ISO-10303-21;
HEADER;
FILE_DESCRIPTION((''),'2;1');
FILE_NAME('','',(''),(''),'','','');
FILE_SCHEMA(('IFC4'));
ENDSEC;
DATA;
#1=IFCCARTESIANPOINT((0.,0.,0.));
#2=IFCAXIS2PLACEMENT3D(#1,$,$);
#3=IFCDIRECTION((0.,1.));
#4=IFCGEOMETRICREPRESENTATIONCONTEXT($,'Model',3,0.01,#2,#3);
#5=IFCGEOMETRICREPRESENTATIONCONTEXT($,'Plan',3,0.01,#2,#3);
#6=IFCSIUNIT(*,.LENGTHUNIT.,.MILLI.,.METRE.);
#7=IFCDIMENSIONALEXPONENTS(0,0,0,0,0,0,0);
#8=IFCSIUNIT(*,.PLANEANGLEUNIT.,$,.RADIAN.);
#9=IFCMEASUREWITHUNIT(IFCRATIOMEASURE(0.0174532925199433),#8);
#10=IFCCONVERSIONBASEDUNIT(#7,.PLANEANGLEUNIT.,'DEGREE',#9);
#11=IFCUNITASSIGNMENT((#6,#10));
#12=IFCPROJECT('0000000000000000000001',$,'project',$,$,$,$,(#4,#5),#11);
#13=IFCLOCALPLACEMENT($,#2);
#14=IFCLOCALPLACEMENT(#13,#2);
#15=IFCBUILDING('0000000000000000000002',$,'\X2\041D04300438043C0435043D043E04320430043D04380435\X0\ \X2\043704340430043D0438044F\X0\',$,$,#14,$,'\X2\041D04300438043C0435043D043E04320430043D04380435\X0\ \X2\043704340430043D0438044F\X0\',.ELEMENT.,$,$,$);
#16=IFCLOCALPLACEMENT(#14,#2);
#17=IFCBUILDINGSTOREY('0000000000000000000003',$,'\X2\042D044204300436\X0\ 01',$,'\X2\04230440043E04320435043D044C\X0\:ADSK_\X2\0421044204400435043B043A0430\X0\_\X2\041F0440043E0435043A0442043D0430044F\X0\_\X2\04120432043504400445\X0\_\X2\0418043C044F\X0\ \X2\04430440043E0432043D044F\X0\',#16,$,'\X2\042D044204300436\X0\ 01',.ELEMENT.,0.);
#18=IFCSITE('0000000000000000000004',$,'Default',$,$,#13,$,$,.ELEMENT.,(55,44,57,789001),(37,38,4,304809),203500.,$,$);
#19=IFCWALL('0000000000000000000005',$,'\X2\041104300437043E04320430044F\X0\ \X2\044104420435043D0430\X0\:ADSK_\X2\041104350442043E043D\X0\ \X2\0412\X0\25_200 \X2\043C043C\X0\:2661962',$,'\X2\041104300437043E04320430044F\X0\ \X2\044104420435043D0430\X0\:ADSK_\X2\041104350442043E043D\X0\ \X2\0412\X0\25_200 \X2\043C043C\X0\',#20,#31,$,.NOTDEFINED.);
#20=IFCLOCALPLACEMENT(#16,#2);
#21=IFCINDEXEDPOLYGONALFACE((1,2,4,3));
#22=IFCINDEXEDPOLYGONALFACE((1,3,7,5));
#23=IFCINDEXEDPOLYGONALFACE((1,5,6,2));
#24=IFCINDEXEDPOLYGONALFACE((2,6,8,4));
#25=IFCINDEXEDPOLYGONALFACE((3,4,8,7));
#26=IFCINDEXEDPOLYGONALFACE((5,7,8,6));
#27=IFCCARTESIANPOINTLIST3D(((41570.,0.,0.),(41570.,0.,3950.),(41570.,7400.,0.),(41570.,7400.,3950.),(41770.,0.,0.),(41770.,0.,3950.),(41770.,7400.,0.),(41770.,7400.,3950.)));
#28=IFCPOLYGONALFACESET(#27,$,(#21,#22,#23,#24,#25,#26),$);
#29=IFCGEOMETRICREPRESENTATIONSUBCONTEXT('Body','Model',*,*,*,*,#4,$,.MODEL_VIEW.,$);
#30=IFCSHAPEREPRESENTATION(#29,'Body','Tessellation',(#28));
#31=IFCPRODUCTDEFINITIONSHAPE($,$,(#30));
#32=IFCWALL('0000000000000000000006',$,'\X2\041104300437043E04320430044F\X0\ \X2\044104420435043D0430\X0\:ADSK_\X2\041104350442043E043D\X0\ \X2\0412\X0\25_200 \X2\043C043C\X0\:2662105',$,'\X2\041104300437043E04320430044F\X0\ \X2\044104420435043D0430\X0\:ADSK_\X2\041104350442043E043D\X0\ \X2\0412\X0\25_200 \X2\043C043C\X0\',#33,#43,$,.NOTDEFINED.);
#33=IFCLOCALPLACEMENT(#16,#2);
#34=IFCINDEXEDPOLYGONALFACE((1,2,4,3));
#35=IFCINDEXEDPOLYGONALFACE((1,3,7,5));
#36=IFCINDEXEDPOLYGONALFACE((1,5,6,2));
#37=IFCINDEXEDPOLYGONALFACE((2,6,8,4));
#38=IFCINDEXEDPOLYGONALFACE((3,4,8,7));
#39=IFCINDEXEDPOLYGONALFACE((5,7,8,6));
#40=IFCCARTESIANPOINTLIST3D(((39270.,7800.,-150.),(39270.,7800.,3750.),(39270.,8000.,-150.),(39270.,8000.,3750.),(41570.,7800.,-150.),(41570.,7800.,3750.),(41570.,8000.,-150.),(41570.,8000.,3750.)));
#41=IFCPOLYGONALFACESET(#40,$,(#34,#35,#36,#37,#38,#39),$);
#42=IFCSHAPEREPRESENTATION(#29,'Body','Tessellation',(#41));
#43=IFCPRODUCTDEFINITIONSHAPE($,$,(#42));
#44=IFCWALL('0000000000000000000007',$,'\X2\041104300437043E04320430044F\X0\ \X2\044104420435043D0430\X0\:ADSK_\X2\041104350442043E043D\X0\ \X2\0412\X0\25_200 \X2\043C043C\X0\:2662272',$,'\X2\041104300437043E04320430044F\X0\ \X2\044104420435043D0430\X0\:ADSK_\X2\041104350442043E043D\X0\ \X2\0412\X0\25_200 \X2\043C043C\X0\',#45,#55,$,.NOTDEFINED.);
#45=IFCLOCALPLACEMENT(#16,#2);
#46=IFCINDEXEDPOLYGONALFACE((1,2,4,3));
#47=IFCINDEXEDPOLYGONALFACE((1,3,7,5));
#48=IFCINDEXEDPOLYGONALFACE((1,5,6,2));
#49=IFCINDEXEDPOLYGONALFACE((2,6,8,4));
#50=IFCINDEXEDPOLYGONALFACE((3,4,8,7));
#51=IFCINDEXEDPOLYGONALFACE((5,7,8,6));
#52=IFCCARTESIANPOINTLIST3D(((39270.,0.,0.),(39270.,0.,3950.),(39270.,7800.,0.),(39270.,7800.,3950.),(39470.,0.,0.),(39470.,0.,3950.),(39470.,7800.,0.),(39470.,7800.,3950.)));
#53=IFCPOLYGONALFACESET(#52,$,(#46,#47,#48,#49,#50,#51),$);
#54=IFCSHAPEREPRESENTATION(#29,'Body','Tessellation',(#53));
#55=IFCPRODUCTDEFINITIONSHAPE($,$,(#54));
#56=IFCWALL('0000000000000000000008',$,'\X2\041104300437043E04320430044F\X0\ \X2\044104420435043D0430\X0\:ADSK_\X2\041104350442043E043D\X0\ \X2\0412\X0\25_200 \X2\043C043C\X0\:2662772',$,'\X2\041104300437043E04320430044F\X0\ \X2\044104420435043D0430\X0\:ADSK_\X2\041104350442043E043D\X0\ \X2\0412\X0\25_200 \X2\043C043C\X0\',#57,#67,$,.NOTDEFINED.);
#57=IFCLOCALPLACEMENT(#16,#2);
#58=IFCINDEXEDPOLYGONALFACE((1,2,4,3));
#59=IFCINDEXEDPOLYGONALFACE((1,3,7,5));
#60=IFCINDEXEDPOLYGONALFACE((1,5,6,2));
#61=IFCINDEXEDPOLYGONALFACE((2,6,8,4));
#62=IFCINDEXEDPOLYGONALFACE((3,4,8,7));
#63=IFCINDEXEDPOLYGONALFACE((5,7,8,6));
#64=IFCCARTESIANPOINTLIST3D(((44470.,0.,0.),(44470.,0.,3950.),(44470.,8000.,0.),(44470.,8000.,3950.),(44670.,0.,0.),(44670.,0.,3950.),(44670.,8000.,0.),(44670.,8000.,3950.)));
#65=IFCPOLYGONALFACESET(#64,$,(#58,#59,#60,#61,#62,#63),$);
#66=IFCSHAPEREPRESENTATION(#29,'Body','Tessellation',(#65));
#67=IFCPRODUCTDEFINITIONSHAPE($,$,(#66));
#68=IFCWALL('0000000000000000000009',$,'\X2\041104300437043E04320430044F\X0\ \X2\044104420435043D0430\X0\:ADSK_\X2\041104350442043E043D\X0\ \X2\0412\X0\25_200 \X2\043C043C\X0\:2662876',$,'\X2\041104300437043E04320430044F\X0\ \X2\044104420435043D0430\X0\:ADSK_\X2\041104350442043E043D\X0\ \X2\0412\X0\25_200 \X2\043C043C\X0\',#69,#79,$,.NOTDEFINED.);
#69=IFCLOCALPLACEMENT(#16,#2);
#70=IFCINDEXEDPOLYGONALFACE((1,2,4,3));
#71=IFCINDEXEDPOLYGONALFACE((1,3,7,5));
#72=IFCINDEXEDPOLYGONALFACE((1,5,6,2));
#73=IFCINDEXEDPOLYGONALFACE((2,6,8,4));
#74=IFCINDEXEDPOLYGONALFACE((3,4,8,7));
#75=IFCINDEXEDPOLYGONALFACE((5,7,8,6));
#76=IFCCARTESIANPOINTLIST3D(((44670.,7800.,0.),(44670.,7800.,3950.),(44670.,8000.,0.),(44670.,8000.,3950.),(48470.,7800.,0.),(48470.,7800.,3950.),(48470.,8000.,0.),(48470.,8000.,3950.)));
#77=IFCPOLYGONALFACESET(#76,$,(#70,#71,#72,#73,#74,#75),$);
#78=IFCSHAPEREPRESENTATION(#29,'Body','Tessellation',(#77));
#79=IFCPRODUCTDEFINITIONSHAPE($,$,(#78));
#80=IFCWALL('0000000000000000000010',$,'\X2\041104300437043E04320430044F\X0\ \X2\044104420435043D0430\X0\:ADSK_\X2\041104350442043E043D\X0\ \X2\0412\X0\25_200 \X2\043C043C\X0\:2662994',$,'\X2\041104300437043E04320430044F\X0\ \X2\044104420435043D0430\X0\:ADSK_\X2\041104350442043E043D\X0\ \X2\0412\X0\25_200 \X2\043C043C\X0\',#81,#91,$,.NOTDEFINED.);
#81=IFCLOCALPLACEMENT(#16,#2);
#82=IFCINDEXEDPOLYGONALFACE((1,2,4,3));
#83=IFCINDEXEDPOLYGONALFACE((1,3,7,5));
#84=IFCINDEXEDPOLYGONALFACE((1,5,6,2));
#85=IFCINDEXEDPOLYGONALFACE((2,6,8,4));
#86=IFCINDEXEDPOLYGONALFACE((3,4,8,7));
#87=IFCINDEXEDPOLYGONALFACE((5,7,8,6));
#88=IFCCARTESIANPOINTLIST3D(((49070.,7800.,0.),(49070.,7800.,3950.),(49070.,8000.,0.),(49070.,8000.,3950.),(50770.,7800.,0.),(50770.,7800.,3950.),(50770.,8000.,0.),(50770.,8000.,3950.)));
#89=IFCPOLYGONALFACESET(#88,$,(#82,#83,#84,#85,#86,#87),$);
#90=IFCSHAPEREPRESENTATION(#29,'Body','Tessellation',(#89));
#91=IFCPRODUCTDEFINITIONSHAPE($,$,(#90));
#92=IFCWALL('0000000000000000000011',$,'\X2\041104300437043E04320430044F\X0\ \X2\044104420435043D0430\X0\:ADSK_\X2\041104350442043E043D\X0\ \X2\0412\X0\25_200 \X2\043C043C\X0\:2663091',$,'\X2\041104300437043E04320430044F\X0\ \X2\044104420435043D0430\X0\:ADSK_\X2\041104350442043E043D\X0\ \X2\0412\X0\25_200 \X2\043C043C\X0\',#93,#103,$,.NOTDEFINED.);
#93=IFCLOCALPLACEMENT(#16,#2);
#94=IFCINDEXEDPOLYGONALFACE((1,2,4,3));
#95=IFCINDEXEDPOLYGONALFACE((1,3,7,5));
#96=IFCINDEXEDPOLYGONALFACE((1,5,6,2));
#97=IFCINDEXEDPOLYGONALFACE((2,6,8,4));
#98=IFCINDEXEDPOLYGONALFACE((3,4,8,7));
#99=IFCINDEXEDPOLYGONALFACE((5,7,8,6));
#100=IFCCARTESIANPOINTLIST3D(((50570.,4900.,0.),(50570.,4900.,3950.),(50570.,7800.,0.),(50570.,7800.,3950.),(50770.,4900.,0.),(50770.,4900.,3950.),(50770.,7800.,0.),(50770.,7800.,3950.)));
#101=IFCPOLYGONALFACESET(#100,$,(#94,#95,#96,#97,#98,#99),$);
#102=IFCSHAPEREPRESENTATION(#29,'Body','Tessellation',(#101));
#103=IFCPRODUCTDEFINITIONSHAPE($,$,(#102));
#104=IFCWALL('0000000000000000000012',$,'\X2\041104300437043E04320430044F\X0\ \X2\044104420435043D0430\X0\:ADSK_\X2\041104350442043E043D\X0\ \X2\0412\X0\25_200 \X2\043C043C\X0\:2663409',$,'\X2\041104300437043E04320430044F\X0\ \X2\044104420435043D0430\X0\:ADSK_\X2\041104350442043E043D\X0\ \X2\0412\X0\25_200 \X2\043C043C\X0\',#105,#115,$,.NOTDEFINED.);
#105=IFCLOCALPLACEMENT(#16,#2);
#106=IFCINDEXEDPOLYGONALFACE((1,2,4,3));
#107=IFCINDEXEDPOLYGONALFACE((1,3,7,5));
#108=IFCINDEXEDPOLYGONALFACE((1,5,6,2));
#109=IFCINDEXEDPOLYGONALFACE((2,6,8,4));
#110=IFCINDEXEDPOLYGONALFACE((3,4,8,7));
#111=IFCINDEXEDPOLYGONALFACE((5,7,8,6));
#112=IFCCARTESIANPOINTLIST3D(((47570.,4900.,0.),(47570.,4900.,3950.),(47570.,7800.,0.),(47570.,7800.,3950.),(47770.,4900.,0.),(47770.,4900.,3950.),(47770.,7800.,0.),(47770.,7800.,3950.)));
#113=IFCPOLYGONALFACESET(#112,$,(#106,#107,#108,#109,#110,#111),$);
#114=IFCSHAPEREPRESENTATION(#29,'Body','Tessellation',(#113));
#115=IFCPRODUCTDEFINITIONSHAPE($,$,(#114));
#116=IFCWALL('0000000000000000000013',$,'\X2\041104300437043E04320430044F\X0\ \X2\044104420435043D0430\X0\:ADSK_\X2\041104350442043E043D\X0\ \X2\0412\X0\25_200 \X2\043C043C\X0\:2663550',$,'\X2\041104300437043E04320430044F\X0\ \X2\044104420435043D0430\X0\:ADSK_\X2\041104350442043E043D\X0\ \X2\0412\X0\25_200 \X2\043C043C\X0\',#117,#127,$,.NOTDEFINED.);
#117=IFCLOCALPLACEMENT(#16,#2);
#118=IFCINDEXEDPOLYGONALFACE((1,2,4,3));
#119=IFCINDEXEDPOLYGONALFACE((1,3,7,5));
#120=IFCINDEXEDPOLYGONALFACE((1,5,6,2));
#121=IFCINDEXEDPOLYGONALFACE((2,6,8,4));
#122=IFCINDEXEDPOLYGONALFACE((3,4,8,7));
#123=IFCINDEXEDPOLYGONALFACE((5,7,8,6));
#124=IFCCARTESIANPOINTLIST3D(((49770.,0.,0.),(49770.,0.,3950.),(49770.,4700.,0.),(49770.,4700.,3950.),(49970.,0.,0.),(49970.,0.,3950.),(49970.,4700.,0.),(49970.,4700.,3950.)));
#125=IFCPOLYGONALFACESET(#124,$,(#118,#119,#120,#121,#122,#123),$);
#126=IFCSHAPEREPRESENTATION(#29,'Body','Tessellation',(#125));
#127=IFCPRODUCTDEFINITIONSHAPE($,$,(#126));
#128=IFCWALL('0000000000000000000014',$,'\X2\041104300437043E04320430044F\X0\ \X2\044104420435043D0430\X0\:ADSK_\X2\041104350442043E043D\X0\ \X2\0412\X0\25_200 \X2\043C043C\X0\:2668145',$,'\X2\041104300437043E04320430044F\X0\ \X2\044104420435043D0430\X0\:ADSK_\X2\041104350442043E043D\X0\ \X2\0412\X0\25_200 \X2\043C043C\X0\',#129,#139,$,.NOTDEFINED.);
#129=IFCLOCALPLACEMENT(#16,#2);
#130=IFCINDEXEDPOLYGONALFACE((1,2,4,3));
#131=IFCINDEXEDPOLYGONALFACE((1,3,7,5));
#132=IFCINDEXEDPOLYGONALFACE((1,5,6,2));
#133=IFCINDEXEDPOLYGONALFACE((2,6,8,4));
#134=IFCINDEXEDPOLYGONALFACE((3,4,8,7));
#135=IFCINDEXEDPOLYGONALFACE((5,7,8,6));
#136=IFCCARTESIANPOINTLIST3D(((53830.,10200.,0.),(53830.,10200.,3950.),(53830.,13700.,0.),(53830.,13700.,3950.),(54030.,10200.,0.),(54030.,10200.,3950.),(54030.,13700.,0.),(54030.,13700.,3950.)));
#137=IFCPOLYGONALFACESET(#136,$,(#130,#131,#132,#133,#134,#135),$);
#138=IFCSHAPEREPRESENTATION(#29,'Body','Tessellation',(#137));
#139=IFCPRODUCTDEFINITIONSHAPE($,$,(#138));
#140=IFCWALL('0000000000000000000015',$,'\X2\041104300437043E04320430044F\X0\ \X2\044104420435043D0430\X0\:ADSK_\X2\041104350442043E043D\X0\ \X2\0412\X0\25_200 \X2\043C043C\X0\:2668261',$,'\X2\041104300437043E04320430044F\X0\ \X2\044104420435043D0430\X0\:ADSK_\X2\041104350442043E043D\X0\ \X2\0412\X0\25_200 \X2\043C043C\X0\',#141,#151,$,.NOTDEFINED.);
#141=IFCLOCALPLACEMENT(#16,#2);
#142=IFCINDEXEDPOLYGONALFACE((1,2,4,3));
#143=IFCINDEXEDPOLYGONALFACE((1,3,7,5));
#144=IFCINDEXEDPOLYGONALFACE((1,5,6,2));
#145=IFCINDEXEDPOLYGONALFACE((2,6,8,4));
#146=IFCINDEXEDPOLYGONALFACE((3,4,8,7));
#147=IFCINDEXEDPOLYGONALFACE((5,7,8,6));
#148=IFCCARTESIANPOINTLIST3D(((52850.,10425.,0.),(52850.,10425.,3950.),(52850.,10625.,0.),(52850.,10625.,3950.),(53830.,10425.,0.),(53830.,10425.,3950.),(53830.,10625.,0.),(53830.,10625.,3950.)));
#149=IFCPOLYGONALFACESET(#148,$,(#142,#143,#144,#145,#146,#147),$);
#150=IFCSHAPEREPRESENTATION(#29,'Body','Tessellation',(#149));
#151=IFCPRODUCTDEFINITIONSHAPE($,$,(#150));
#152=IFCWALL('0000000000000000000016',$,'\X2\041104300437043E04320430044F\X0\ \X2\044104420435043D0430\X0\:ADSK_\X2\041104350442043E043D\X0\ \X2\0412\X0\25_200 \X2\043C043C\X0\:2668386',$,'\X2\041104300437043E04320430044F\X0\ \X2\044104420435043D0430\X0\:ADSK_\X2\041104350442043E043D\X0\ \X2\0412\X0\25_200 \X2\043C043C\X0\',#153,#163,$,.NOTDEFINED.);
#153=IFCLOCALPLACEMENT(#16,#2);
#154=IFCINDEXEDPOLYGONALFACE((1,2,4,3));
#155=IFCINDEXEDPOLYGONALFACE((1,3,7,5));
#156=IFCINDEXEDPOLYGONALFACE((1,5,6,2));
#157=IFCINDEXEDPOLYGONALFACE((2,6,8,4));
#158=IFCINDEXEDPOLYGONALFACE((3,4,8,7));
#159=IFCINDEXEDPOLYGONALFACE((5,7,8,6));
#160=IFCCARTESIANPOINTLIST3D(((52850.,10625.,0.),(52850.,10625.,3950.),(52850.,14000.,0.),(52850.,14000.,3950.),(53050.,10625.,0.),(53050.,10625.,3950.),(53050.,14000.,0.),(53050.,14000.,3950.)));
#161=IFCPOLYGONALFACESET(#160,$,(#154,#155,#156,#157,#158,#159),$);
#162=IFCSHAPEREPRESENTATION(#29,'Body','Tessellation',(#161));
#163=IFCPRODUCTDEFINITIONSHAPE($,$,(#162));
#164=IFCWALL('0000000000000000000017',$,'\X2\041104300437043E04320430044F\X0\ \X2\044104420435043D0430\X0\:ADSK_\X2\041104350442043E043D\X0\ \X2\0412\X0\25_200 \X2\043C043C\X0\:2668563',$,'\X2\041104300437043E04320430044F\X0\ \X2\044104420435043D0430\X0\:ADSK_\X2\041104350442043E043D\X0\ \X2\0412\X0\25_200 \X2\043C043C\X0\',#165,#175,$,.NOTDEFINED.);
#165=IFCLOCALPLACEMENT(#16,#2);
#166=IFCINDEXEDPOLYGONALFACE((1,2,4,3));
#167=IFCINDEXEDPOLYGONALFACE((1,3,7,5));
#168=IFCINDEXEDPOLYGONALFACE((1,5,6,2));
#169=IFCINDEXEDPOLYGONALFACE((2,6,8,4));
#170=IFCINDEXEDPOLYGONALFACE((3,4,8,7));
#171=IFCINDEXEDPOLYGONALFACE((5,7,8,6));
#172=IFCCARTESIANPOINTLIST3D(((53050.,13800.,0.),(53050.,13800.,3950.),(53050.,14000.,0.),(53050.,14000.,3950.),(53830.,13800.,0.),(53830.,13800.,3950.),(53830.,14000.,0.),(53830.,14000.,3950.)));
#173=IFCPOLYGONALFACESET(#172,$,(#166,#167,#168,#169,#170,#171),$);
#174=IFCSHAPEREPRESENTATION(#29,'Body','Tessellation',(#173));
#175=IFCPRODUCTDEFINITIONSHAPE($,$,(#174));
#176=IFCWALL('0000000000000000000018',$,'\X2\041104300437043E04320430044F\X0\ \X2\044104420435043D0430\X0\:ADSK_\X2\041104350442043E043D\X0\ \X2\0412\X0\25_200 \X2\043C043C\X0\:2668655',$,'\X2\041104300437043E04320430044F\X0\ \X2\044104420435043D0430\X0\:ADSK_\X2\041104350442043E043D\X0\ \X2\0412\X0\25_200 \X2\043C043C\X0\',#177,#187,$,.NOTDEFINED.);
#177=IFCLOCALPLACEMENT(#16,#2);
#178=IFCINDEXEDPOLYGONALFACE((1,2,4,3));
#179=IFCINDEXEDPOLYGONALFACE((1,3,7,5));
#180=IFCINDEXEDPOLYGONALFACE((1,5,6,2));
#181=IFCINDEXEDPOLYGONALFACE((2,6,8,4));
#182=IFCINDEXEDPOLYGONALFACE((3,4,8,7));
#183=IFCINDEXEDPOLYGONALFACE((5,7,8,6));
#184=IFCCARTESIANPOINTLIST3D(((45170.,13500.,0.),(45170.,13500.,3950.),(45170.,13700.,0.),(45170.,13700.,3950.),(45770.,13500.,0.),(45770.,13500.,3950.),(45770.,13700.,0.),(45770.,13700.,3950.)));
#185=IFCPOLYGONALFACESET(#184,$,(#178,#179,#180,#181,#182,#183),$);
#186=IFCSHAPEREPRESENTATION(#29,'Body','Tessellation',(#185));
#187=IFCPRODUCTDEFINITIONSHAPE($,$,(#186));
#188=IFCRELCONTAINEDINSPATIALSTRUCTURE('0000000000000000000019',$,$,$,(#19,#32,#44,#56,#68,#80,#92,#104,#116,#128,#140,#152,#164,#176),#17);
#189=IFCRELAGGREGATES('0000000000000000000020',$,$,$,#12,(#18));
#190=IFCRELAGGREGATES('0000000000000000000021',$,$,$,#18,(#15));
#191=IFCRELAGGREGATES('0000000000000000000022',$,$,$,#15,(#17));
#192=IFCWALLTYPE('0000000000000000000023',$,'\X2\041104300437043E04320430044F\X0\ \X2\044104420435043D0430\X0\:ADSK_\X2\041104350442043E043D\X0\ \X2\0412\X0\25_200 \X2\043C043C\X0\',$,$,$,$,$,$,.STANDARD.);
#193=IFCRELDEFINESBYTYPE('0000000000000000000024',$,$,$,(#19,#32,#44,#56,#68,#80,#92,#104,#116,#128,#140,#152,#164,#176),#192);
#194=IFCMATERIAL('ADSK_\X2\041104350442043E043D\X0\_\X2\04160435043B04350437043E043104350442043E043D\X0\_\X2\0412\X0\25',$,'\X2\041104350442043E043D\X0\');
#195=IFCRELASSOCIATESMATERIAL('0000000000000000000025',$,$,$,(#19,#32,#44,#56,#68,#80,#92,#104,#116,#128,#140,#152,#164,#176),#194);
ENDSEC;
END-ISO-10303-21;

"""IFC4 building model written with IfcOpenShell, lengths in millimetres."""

from ifc_helpers import new_model, entity, si_unit, converted_unit, direction, frame, origin, place, context, subcontext, project, spatial, indexed_curve, outline, extrude, material, type_object, element, save


model = new_model("IFC4")

# Units and contexts
model_context = context("Model", 3, precision=0.01, world=origin(), true_north=direction((0.0, 1.0)))
plan_context = context("Plan", 3, precision=0.01, world=origin(), true_north=direction((0.0, 1.0)))
body_context = subcontext(model_context, "Body", "Model", "MODEL_VIEW")
ifc_project = project(units=[si_unit("LENGTHUNIT", "METRE", prefix="MILLI"), converted_unit("PLANEANGLEUNIT", "DEGREE", entity("IfcRatioMeasure", 0.0174532925199433), si_unit("PLANEANGLEUNIT", "RADIAN"), dimensions=[0, 0, 0, 0, 0, 0, 0])], contexts=[model_context, plan_context])

# Site, building, storey
site_placement = place(None, origin())
site = spatial("IfcSite", under=ifc_project, at=site_placement, Name="Default", CompositionType="ELEMENT", RefLatitude=(55, 44, 57, 789001), RefLongitude=(37, 38, 4, 304809), RefElevation=203500.0)
building_placement = place(site_placement, origin())
building = spatial("IfcBuilding", under=site, at=building_placement, Name="Наименование здания", LongName="Наименование здания", CompositionType="ELEMENT")
storey_placement = place(building_placement, origin())
storey = spatial("IfcBuildingStorey", under=building, at=storey_placement, Name="Этаж 01", ObjectType="Уровень:ADSK_Стрелка_Проектная_Вверх_Имя уровня", LongName="Этаж 01", CompositionType="ELEMENT", Elevation=0.0)

# Walls
ifc_material = material(Name="ADSK_Бетон_Железобетон_В25", Category="Бетон")
wall_type_1 = type_object("IfcWallType", Name="Базовая стена:ADSK_Бетон В25_200 мм", PredefinedType="STANDARD")
wall_1_placement = place(storey_placement, frame((41670.0, 7400.0, 0.0), z_axis=(0.0, 0.0, 1.0), x_axis=(0.0, -1.0, 0.0)))
element("IfcWall", 1, at=wall_1_placement, inside=storey, type_object=wall_type_1, material=ifc_material, Name="Базовая стена:ADSK_Бетон В25_200 мм:2661962", ObjectType="Базовая стена:ADSK_Бетон В25_200 мм", PredefinedType="NOTDEFINED", context=body_context, shape_type="SweptSolid", body=[
    extrude(outline(indexed_curve([(7400.0, 100.0), (0.0, 100.0), (0.0, -100.0), (7400.0, -100.0), (7400.0, 100.0)], self_intersect=False)), origin(), (0.0, 0.0, 1.0), 3950.0),
])
wall_2_placement = place(storey_placement, frame((41570.0, 7900.0, -150.0), z_axis=(0.0, 0.0, 1.0), x_axis=(-1.0, 0.0, 0.0)))
element("IfcWall", 2, at=wall_2_placement, inside=storey, type_object=wall_type_1, material=ifc_material, Name="Базовая стена:ADSK_Бетон В25_200 мм:2662105", ObjectType="Базовая стена:ADSK_Бетон В25_200 мм", PredefinedType="NOTDEFINED", context=body_context, shape_type="SweptSolid", body=[
    extrude(outline(indexed_curve([(2300.0, 100.0), (0.0, 100.0), (0.0, -100.0), (2300.0, -100.0), (2300.0, 100.0)], self_intersect=False)), origin(), (0.0, 0.0, 1.0), 3900.0),
])
wall_3_placement = place(storey_placement, frame((39370.0, 7800.0, 0.0), z_axis=(0.0, 0.0, 1.0), x_axis=(0.0, -1.0, 0.0)))
element("IfcWall", 3, at=wall_3_placement, inside=storey, type_object=wall_type_1, material=ifc_material, Name="Базовая стена:ADSK_Бетон В25_200 мм:2662272", ObjectType="Базовая стена:ADSK_Бетон В25_200 мм", PredefinedType="NOTDEFINED", context=body_context, shape_type="SweptSolid", body=[
    extrude(outline(indexed_curve([(7800.0, 100.0), (0.0, 100.0), (0.0, -100.0), (7800.0, -100.0), (7800.0, 100.0)], self_intersect=False)), origin(), (0.0, 0.0, 1.0), 3950.0),
])
wall_4_placement = place(storey_placement, frame((44570.0, 0.0, 0.0), z_axis=(0.0, 0.0, 1.0), x_axis=(0.0, 1.0, 0.0)))
element("IfcWall", 4, at=wall_4_placement, inside=storey, type_object=wall_type_1, material=ifc_material, Name="Базовая стена:ADSK_Бетон В25_200 мм:2662772", ObjectType="Базовая стена:ADSK_Бетон В25_200 мм", PredefinedType="NOTDEFINED", context=body_context, shape_type="SweptSolid", body=[
    extrude(outline(indexed_curve([(8000.0, 100.0), (0.0, 100.0), (0.0, -100.0), (8000.0, -100.0), (8000.0, 100.0)], self_intersect=False)), origin(), (0.0, 0.0, 1.0), 3950.0),
])
wall_5_placement = place(storey_placement, frame((48470.0, 7900.0, 0.0), z_axis=(0.0, 0.0, 1.0), x_axis=(-1.0, 0.0, 0.0)))
element("IfcWall", 5, at=wall_5_placement, inside=storey, type_object=wall_type_1, material=ifc_material, Name="Базовая стена:ADSK_Бетон В25_200 мм:2662876", ObjectType="Базовая стена:ADSK_Бетон В25_200 мм", PredefinedType="NOTDEFINED", context=body_context, shape_type="SweptSolid", body=[
    extrude(outline(indexed_curve([(3800.0, 100.0), (0.0, 100.0), (0.0, -100.0), (3800.0, -100.0), (3800.0, 100.0)], self_intersect=False)), origin(), (0.0, 0.0, 1.0), 3950.0),
])
wall_6_placement = place(storey_placement, frame((49070.0, 7900.0, 0.0)))
element("IfcWall", 6, at=wall_6_placement, inside=storey, type_object=wall_type_1, material=ifc_material, Name="Базовая стена:ADSK_Бетон В25_200 мм:2662994", ObjectType="Базовая стена:ADSK_Бетон В25_200 мм", PredefinedType="NOTDEFINED", context=body_context, shape_type="SweptSolid", body=[
    extrude(outline(indexed_curve([(1700.0, 100.0), (0.0, 100.0), (0.0, -100.0), (1700.0, -100.0), (1700.0, 100.0)], self_intersect=False)), origin(), (0.0, 0.0, 1.0), 3950.0),
])
for number, where, z_axis, x_axis, name in (
    (7, (50670.0, 7800.0, 0.0), (0.0, 0.0, 1.0), (0.0, -1.0, 0.0), "Базовая стена:ADSK_Бетон В25_200 мм:2663091"),
    (8, (47670.0, 7800.0, 0.0), (0.0, 0.0, 1.0), (0.0, -1.0, 0.0), "Базовая стена:ADSK_Бетон В25_200 мм:2663409"),
):
    element("IfcWall", number, at=place(storey_placement, frame(where, z_axis=z_axis, x_axis=x_axis)), inside=storey, type_object=wall_type_1, material=ifc_material, Name=name, ObjectType="Базовая стена:ADSK_Бетон В25_200 мм", PredefinedType="NOTDEFINED", context=body_context, shape_type="SweptSolid", body=[
        extrude(outline(indexed_curve([(2900.0, 100.0), (0.0, 100.0), (0.0, -100.0), (2900.0, -100.0), (2900.0, 100.0)], self_intersect=False)), origin(), (0.0, 0.0, 1.0), 3950.0),
    ])
wall_7_placement = place(storey_placement, frame((49870.0, 0.0, 0.0), z_axis=(0.0, 0.0, 1.0), x_axis=(0.0, 1.0, 0.0)))
element("IfcWall", 9, at=wall_7_placement, inside=storey, type_object=wall_type_1, material=ifc_material, Name="Базовая стена:ADSK_Бетон В25_200 мм:2663550", ObjectType="Базовая стена:ADSK_Бетон В25_200 мм", PredefinedType="NOTDEFINED", context=body_context, shape_type="SweptSolid", body=[
    extrude(outline(indexed_curve([(4700.0, 100.0), (0.0, 100.0), (0.0, -100.0), (4700.0, -100.0), (4700.0, 100.0)], self_intersect=False)), origin(), (0.0, 0.0, 1.0), 3950.0),
])
wall_8_placement = place(storey_placement, frame((53930.0, 10200.0, 0.0), z_axis=(0.0, 0.0, 1.0), x_axis=(0.0, 1.0, 0.0)))
element("IfcWall", 10, at=wall_8_placement, inside=storey, type_object=wall_type_1, material=ifc_material, Name="Базовая стена:ADSK_Бетон В25_200 мм:2668145", ObjectType="Базовая стена:ADSK_Бетон В25_200 мм", PredefinedType="NOTDEFINED", context=body_context, shape_type="SweptSolid", body=[
    extrude(outline(indexed_curve([(3500.0, 100.0), (0.0, 100.0), (0.0, -100.0), (3500.0, -100.0), (3500.0, 100.0)], self_intersect=False)), origin(), (0.0, 0.0, 1.0), 3950.0),
])
wall_9_placement = place(storey_placement, frame((53830.0, 10525.0, 0.0), z_axis=(0.0, 0.0, 1.0), x_axis=(-1.0, 0.0, 0.0)))
element("IfcWall", 11, at=wall_9_placement, inside=storey, type_object=wall_type_1, material=ifc_material, Name="Базовая стена:ADSK_Бетон В25_200 мм:2668261", ObjectType="Базовая стена:ADSK_Бетон В25_200 мм", PredefinedType="NOTDEFINED", context=body_context, shape_type="SweptSolid", body=[
    extrude(outline(indexed_curve([(980.0, 100.0), (0.0, 100.0), (0.0, -100.0), (980.0, -100.0), (980.0, 100.0)], self_intersect=False)), origin(), (0.0, 0.0, 1.0), 3950.0),
])
wall_10_placement = place(storey_placement, frame((52950.0, 10625.0, 0.0), z_axis=(0.0, 0.0, 1.0), x_axis=(0.0, 1.0, 0.0)))
element("IfcWall", 12, at=wall_10_placement, inside=storey, type_object=wall_type_1, material=ifc_material, Name="Базовая стена:ADSK_Бетон В25_200 мм:2668386", ObjectType="Базовая стена:ADSK_Бетон В25_200 мм", PredefinedType="NOTDEFINED", context=body_context, shape_type="SweptSolid", body=[
    extrude(outline(indexed_curve([(3375.0, 100.0), (0.0, 100.0), (0.0, -100.0), (3375.0, -100.0), (3375.0, 100.0)], self_intersect=False)), origin(), (0.0, 0.0, 1.0), 3950.0),
])
wall_11_placement = place(storey_placement, frame((53830.0, 13900.0, 0.0), z_axis=(0.0, 0.0, 1.0), x_axis=(-1.0, 0.0, 0.0)))
element("IfcWall", 13, at=wall_11_placement, inside=storey, type_object=wall_type_1, material=ifc_material, Name="Базовая стена:ADSK_Бетон В25_200 мм:2668563", ObjectType="Базовая стена:ADSK_Бетон В25_200 мм", PredefinedType="NOTDEFINED", context=body_context, shape_type="SweptSolid", body=[
    extrude(outline(indexed_curve([(780.0, 100.0), (0.0, 100.0), (0.0, -100.0), (780.0, -100.0), (780.0, 100.0)], self_intersect=False)), origin(), (0.0, 0.0, 1.0), 3950.0),
])
wall_12_placement = place(storey_placement, frame((45170.0, 13600.0, 0.0)))
element("IfcWall", 14, at=wall_12_placement, inside=storey, type_object=wall_type_1, material=ifc_material, Name="Базовая стена:ADSK_Бетон В25_200 мм:2668655", ObjectType="Базовая стена:ADSK_Бетон В25_200 мм", PredefinedType="NOTDEFINED", context=body_context, shape_type="SweptSolid", body=[
    extrude(outline(indexed_curve([(600.0, 100.0), (0.0, 100.0), (0.0, -100.0), (600.0, -100.0), (600.0, 100.0)], self_intersect=False)), origin(), (0.0, 0.0, 1.0), 3950.0),
])

save(model, "model.ifc")
